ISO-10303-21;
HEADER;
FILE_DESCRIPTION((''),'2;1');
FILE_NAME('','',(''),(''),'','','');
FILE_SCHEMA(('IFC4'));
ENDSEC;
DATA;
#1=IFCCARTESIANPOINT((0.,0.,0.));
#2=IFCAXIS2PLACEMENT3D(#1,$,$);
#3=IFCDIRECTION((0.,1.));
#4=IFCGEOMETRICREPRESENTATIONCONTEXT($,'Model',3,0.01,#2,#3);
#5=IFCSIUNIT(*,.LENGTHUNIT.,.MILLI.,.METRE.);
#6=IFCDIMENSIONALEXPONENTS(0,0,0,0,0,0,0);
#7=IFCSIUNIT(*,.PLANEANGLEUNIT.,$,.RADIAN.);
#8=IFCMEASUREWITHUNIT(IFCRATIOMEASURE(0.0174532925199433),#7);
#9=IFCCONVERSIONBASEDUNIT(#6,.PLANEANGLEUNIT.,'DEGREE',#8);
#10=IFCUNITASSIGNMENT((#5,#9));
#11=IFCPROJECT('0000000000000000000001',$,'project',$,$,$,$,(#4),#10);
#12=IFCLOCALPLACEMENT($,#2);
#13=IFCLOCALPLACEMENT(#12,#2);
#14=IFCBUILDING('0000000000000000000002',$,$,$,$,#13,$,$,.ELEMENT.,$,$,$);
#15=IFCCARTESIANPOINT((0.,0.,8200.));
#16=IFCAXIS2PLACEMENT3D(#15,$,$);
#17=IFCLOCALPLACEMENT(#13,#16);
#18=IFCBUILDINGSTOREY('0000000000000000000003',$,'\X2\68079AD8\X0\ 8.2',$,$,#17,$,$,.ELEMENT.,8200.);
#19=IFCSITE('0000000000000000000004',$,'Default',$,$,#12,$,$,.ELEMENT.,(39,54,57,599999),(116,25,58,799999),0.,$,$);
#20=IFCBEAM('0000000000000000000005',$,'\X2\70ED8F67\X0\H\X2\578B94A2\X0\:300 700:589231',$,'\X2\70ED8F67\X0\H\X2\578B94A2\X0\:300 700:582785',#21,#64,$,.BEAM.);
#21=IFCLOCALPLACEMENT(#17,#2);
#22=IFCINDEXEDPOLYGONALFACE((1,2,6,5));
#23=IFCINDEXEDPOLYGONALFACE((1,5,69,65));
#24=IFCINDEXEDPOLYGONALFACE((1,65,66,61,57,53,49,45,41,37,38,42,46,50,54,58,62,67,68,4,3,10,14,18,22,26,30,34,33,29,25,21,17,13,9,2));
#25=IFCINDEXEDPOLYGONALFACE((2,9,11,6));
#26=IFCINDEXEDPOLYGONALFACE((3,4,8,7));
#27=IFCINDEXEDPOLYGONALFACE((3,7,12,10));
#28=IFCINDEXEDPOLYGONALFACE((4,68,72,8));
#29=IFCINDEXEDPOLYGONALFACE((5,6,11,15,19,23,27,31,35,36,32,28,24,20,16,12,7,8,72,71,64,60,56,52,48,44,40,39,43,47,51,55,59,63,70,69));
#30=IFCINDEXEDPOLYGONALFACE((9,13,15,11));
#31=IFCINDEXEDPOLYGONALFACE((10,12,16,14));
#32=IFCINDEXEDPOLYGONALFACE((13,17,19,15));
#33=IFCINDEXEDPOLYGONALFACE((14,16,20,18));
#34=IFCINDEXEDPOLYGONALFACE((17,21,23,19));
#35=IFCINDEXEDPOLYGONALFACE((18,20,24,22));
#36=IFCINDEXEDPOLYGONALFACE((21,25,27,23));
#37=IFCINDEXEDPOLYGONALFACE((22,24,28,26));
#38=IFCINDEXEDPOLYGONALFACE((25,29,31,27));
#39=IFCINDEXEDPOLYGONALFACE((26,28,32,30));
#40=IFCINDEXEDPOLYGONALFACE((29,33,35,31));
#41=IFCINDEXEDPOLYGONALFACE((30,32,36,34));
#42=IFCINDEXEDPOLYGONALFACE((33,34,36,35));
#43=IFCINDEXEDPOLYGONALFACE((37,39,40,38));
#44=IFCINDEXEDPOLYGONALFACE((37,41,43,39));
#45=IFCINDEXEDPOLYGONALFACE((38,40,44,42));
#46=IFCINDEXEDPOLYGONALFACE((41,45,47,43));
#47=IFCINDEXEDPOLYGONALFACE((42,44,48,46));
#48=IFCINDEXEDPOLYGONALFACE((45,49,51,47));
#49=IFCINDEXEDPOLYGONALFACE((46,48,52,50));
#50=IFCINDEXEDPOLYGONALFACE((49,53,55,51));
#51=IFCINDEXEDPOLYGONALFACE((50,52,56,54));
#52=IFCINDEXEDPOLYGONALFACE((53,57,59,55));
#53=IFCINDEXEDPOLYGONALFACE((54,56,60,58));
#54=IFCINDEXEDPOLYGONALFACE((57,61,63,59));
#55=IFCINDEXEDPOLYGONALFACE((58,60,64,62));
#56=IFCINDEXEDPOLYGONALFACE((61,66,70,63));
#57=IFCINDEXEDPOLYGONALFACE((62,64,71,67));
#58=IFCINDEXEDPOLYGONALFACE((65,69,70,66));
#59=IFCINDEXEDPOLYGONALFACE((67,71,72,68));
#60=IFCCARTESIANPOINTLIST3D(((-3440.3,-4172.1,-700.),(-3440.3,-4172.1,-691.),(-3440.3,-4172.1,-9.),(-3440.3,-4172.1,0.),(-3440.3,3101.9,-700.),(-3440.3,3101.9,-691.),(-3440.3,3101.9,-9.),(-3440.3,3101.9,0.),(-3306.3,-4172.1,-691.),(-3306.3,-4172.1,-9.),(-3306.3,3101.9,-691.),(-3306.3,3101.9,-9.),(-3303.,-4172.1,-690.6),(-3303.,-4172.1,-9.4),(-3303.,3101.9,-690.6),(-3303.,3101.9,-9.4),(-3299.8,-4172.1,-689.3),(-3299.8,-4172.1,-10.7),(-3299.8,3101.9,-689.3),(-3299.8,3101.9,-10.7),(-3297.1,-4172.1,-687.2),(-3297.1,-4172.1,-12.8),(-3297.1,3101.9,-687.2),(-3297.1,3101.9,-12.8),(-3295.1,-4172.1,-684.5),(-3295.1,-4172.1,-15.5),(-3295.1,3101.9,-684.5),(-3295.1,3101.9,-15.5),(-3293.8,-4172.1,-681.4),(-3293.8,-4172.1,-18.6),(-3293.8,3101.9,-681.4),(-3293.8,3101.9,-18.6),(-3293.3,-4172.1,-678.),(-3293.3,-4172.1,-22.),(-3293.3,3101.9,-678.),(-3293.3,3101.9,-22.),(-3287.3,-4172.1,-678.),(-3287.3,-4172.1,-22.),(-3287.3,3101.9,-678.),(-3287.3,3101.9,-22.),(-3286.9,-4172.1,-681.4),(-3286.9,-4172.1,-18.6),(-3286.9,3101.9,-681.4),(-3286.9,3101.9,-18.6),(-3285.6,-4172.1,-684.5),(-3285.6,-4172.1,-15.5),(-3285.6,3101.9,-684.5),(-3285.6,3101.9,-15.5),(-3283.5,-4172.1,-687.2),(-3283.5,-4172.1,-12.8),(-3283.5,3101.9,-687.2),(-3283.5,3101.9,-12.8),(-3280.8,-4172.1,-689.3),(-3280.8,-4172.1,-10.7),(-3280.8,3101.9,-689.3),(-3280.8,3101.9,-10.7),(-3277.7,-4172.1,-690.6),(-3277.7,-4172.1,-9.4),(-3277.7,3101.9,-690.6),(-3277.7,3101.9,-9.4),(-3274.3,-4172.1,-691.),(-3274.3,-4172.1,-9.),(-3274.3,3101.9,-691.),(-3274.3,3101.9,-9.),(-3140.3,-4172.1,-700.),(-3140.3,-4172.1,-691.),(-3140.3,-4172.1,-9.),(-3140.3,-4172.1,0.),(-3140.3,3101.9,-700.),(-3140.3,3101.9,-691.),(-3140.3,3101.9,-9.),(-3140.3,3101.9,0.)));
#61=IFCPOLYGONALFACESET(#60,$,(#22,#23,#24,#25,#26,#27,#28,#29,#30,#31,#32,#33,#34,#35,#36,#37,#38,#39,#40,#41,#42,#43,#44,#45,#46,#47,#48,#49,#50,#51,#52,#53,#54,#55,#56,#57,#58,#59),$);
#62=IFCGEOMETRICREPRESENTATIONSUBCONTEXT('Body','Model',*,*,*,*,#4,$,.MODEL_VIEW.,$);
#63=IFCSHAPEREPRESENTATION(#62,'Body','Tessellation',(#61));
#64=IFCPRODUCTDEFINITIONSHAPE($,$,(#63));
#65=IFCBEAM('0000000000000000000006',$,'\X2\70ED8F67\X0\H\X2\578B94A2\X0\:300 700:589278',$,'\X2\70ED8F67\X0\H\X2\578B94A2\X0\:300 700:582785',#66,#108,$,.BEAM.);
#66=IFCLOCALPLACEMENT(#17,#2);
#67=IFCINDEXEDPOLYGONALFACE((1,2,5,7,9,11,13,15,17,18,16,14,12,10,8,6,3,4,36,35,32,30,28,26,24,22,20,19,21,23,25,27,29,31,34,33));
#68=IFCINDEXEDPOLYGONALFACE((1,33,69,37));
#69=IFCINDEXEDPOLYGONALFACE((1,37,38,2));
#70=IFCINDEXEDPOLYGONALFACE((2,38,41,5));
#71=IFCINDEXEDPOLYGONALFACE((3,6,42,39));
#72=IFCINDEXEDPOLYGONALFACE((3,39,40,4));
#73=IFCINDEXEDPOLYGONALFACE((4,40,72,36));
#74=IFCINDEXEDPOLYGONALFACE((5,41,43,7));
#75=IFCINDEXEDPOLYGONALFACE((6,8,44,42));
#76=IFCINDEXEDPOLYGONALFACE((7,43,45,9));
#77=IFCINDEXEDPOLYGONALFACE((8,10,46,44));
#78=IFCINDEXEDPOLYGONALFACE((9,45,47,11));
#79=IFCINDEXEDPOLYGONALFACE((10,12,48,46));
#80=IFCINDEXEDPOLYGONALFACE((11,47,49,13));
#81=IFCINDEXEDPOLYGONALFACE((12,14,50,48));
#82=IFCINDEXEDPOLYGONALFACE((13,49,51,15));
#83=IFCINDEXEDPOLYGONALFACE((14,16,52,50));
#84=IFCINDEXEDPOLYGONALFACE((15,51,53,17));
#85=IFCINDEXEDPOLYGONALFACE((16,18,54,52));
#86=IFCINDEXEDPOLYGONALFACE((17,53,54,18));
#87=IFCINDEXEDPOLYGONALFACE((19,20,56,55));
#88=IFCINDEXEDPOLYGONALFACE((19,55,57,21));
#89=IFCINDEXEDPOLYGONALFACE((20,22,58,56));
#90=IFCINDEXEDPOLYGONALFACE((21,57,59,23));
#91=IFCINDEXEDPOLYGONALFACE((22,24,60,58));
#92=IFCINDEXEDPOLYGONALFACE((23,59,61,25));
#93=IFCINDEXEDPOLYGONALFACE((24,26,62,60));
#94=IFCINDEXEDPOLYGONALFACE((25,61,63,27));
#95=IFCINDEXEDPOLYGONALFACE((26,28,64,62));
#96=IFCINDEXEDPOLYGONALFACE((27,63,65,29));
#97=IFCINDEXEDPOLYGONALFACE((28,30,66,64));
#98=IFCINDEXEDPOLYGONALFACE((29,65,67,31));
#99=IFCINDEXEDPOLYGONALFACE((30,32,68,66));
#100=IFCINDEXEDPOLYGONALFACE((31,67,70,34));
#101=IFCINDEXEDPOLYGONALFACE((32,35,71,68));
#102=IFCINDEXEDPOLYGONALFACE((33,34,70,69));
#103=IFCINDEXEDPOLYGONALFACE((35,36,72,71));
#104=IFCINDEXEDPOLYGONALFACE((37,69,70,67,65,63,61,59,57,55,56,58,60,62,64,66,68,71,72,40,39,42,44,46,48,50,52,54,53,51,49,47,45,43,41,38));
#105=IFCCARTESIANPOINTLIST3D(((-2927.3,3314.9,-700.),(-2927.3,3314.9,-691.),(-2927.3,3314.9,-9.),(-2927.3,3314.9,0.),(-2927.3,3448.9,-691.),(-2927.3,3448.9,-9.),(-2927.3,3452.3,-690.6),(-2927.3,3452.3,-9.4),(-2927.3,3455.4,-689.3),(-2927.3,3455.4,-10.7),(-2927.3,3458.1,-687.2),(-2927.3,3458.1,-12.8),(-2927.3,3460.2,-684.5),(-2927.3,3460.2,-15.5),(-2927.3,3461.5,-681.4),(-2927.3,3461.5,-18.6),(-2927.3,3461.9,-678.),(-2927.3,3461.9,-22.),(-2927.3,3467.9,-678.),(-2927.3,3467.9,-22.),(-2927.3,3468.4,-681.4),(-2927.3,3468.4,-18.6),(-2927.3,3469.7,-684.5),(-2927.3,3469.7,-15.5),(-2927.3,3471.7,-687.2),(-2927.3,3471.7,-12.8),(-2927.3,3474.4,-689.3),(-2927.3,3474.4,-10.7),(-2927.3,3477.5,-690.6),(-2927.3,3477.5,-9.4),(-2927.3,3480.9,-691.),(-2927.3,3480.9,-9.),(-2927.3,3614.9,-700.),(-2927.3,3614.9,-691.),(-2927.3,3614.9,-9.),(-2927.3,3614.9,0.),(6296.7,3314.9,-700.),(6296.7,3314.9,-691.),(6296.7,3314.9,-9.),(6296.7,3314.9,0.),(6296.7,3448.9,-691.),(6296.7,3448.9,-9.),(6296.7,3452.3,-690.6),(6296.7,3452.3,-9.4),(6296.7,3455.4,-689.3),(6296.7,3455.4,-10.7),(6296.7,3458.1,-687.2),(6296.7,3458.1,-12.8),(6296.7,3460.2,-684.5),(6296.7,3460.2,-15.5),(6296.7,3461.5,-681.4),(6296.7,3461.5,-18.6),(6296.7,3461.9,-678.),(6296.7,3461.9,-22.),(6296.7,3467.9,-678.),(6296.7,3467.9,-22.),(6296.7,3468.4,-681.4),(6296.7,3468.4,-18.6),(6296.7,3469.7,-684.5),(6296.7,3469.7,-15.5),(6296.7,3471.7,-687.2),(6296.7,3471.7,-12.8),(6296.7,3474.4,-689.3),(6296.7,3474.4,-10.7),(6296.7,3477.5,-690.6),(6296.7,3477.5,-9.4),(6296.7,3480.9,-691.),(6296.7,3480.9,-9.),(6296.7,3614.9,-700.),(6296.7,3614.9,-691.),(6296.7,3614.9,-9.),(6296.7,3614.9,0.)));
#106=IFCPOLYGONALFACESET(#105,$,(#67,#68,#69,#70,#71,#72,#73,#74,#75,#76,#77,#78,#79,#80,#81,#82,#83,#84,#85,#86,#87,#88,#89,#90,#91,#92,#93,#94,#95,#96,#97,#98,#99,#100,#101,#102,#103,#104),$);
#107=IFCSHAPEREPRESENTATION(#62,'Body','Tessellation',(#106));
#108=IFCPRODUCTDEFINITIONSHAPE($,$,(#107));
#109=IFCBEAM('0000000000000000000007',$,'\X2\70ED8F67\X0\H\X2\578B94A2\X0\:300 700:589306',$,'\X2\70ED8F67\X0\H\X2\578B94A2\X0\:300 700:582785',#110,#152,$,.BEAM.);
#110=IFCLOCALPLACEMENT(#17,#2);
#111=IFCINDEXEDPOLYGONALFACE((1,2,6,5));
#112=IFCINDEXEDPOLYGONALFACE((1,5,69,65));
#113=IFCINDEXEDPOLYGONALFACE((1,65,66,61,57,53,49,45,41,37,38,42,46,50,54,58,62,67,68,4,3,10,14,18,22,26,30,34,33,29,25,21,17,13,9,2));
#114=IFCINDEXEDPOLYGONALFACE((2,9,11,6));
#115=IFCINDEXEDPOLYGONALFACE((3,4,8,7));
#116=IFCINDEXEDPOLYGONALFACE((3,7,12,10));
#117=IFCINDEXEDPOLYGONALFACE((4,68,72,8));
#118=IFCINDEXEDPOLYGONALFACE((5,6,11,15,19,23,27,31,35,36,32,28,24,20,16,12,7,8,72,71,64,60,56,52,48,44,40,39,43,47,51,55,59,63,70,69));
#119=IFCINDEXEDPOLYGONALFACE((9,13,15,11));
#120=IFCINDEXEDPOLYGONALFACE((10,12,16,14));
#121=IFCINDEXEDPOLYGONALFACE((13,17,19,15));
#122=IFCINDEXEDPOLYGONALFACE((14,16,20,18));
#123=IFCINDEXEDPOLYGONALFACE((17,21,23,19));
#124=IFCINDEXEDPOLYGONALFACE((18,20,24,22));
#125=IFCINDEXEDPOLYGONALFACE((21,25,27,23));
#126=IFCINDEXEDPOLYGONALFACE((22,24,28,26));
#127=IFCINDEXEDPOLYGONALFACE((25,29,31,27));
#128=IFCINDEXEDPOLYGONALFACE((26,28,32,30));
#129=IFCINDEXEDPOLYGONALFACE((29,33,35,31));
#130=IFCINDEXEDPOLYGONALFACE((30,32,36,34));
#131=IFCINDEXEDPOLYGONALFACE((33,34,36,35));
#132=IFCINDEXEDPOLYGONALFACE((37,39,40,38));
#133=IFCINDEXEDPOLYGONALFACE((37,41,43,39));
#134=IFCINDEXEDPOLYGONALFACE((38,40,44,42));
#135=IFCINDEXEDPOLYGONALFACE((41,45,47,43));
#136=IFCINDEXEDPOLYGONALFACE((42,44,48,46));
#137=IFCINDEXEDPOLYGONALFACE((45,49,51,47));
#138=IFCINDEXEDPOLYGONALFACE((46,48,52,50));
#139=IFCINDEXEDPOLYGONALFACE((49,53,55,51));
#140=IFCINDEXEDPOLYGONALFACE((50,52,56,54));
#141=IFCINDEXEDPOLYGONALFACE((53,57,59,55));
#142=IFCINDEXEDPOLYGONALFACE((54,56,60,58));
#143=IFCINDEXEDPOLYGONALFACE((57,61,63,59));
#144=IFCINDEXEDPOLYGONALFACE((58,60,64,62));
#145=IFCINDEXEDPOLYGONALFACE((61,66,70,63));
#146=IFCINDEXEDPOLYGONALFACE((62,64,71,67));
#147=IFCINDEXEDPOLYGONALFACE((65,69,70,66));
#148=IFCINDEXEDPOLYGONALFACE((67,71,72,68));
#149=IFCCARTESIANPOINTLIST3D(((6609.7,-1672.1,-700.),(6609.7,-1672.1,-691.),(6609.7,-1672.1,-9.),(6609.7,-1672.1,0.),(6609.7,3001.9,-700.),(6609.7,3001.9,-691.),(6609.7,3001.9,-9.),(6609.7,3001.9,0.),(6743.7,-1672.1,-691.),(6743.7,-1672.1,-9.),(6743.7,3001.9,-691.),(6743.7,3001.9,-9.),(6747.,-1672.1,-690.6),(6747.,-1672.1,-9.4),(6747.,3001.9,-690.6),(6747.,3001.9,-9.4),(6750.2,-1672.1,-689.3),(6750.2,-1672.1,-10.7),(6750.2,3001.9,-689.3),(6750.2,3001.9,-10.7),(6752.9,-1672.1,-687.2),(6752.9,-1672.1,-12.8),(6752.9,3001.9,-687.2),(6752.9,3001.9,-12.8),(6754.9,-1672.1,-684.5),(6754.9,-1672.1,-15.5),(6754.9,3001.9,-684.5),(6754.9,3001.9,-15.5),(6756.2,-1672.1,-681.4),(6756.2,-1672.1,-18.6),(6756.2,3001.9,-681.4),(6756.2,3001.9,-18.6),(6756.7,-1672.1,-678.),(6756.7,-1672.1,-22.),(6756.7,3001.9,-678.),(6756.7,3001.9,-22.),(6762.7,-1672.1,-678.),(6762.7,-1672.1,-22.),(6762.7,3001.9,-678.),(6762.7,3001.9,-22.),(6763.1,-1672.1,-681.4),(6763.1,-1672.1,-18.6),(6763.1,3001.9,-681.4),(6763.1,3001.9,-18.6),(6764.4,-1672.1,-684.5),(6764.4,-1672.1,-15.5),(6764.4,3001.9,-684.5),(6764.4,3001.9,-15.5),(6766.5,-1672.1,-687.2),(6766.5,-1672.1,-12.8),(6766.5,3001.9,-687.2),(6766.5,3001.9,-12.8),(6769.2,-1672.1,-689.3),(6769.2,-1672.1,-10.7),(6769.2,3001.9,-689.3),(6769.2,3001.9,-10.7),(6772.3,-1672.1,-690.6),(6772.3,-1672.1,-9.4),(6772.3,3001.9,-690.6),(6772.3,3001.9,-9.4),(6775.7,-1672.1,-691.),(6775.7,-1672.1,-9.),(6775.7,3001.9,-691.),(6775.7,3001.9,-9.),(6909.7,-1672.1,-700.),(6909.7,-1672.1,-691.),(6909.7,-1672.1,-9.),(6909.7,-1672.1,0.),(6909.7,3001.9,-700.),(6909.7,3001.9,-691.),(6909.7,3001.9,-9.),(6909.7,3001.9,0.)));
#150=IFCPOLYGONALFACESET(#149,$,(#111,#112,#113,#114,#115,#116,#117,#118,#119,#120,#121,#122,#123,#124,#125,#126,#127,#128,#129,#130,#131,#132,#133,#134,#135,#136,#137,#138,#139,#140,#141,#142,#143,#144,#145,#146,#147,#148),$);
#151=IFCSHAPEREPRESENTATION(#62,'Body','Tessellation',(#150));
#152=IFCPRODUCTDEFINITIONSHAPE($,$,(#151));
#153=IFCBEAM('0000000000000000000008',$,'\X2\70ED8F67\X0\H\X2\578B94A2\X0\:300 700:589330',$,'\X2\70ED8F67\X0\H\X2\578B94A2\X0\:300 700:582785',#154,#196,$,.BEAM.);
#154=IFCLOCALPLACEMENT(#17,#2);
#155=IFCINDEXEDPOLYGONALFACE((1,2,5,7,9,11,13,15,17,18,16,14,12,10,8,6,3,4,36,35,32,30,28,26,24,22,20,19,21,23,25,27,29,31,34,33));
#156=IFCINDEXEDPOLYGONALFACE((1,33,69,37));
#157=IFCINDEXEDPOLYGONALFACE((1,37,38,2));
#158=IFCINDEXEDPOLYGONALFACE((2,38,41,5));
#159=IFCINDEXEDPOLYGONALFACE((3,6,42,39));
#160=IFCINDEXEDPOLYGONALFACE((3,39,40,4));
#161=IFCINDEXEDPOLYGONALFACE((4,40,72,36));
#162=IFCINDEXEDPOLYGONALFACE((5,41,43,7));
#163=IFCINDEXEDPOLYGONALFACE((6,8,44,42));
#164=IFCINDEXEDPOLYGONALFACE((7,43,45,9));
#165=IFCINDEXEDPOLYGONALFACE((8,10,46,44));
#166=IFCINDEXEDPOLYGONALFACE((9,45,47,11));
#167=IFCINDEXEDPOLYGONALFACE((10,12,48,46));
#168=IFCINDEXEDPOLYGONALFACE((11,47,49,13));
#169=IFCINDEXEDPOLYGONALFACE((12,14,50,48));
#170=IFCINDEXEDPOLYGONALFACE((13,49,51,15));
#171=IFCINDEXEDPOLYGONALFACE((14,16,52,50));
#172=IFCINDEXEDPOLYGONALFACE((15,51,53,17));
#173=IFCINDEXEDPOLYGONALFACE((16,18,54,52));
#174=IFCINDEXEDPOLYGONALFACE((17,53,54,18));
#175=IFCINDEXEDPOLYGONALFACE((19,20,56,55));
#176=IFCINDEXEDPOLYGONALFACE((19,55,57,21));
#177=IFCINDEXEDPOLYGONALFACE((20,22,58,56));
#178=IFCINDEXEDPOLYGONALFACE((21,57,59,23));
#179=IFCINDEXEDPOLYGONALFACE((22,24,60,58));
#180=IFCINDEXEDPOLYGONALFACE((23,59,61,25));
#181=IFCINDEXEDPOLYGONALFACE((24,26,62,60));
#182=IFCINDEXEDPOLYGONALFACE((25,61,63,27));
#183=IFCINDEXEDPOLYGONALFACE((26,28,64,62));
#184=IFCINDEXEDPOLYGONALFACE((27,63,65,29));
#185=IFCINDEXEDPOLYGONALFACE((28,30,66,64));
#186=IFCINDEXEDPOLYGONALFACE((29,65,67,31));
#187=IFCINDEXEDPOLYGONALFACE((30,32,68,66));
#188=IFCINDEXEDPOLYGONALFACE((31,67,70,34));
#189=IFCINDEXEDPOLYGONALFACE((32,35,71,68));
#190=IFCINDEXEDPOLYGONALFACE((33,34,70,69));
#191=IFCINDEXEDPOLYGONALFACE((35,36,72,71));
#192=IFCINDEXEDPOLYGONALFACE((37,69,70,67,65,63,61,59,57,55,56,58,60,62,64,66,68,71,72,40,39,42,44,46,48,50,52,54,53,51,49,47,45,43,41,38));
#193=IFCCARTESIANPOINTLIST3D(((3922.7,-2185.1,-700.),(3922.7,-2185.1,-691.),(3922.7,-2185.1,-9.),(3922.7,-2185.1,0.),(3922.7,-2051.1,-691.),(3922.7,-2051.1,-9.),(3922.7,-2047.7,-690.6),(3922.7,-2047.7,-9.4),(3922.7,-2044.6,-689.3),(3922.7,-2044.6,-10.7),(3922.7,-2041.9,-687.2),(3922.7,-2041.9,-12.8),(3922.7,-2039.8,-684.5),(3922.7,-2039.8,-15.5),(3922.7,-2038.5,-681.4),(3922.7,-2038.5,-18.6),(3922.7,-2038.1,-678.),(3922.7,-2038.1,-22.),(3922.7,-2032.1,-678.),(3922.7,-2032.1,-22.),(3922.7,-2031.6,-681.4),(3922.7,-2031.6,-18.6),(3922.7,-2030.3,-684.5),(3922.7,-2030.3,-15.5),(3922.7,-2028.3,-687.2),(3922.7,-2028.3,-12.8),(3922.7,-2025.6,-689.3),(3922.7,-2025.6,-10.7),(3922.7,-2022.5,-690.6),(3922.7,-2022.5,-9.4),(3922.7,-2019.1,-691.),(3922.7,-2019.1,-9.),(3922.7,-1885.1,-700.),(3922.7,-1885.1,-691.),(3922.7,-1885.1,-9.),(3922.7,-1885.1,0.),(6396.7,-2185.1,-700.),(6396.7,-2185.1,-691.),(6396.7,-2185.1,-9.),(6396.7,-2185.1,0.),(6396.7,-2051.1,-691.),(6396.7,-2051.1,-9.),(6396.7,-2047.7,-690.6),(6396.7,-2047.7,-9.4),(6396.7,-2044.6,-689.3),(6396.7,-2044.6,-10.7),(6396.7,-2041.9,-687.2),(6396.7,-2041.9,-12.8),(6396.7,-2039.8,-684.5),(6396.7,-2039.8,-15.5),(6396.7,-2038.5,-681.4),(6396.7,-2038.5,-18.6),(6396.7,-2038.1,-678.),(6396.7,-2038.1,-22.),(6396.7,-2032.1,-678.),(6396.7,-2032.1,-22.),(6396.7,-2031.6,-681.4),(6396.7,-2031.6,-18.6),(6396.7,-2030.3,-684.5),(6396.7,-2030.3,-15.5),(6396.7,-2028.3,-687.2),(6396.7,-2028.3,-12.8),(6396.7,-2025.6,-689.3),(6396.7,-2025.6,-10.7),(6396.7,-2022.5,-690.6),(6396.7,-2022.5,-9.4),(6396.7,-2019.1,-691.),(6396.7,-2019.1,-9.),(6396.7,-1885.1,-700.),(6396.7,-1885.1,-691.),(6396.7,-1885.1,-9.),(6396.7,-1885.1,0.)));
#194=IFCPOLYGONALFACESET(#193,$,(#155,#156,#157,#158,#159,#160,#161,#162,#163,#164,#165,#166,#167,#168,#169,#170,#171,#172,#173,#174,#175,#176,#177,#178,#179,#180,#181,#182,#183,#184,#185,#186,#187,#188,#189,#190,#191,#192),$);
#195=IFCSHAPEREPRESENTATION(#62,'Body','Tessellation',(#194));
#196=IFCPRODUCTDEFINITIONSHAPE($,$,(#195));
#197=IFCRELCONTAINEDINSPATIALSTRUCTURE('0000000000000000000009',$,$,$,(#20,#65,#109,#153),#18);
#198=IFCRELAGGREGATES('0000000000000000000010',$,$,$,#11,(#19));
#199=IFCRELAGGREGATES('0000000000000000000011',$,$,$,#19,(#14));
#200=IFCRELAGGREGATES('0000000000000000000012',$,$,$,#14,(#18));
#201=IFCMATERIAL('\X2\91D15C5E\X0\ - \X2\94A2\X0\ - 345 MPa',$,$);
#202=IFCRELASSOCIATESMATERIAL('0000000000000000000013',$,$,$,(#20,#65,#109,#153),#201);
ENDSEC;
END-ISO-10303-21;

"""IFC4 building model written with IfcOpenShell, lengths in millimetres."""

from ifc_helpers import new_model, entity, si_unit, converted_unit, direction, frame, frame_2d, origin, place, context, subcontext, project, spatial, i_section, extrude, material, element, save


model = new_model("IFC4")

# Units and contexts
model_context = context("Model", 3, precision=0.01, world=origin(), true_north=direction((0.0, 1.0)))
body_context = subcontext(model_context, "Body", "Model", "MODEL_VIEW")
ifc_project = project(units=[si_unit("LENGTHUNIT", "METRE", prefix="MILLI"), converted_unit("PLANEANGLEUNIT", "DEGREE", entity("IfcRatioMeasure", 0.0174532925199433), si_unit("PLANEANGLEUNIT", "RADIAN"), dimensions=[0, 0, 0, 0, 0, 0, 0])], contexts=[model_context])

# Site, building, storey
site_placement = place(None, origin())
site = spatial("IfcSite", under=ifc_project, at=site_placement, Name="Default", CompositionType="ELEMENT", RefLatitude=(39, 54, 57, 599999), RefLongitude=(116, 25, 58, 799999), RefElevation=0.0)
building_placement = place(site_placement, origin())
building = spatial("IfcBuilding", under=site, at=building_placement, CompositionType="ELEMENT")
storey_placement = place(building_placement, frame((0.0, 0.0, 8200.0)))
storey = spatial("IfcBuildingStorey", under=building, at=storey_placement, Name="标高 8.2", CompositionType="ELEMENT", Elevation=8200.0)

# Beams
ifc_material_1 = material(Name="金属 - 钢 - 345 MPa")
beam_1_placement = place(storey_placement, frame((-3290.3, 3114.9, 0.0), z_axis=(0.0, 0.0, 1.0), x_axis=(0.0, -1.0, 0.0)))
element("IfcBeam", 1, at=beam_1_placement, inside=storey, material=ifc_material_1, Name="热轧H型钢:300 700:589231", ObjectType="热轧H型钢:300 700:582785", PredefinedType="BEAM", context=body_context, shape_type="SweptSolid", body=[
    extrude(i_section(OverallWidth=300.0, OverallDepth=700.0, WebThickness=6.0, FlangeThickness=9.0, FilletRadius=13.0, at=frame_2d((0.0, 0.0), x_axis=(0.0, 1.0))), frame((13.0, 0.0, -350.0), z_axis=(1.0, 0.0, 0.0), x_axis=(0.0, 0.0, -1.0)), (0.0, 0.0, 1.0), 7274.0),
])
beam_2_placement = place(storey_placement, frame((-2940.3, 3464.9, 0.0)))
element("IfcBeam", 2, at=beam_2_placement, inside=storey, material=ifc_material_1, Name="热轧H型钢:300 700:589278", ObjectType="热轧H型钢:300 700:582785", PredefinedType="BEAM", context=body_context, shape_type="SweptSolid", body=[
    extrude(i_section(OverallWidth=300.0, OverallDepth=700.0, WebThickness=6.0, FlangeThickness=9.0, FilletRadius=13.0, at=frame_2d((0.0, 0.0), x_axis=(0.0, 1.0))), frame((13.0, 0.0, -350.0), z_axis=(1.0, 0.0, 0.0), x_axis=(0.0, 0.0, -1.0)), (0.0, 0.0, 1.0), 9224.0),
])
beam_3_placement = place(storey_placement, frame((6759.7, 3014.9, 0.0), z_axis=(0.0, 0.0, 1.0), x_axis=(0.0, -1.0, 0.0)))
element("IfcBeam", 3, at=beam_3_placement, inside=storey, material=ifc_material_1, Name="热轧H型钢:300 700:589306", ObjectType="热轧H型钢:300 700:582785", PredefinedType="BEAM", context=body_context, shape_type="SweptSolid", body=[
    extrude(i_section(OverallWidth=300.0, OverallDepth=700.0, WebThickness=6.0, FlangeThickness=9.0, FilletRadius=13.0, at=frame_2d((0.0, 0.0), x_axis=(0.0, 1.0))), frame((13.0, 0.0, -350.0), z_axis=(1.0, 0.0, 0.0), x_axis=(0.0, 0.0, -1.0)), (0.0, 0.0, 1.0), 4674.0),
])
beam_4_placement = place(storey_placement, frame((6409.7, -2035.1, 0.0), z_axis=(0.0, 0.0, 1.0), x_axis=(-1.0, 0.0, 0.0)))
element("IfcBeam", 4, at=beam_4_placement, inside=storey, material=ifc_material_1, Name="热轧H型钢:300 700:589330", ObjectType="热轧H型钢:300 700:582785", PredefinedType="BEAM", context=body_context, shape_type="SweptSolid", body=[
    extrude(i_section(OverallWidth=300.0, OverallDepth=700.0, WebThickness=6.0, FlangeThickness=9.0, FilletRadius=13.0, at=frame_2d((0.0, 0.0), x_axis=(0.0, 1.0))), frame((13.0, 0.0, -350.0), z_axis=(1.0, 0.0, 0.0), x_axis=(0.0, 0.0, -1.0)), (0.0, 0.0, 1.0), 2474.0),
])

save(model, "model.ifc")
